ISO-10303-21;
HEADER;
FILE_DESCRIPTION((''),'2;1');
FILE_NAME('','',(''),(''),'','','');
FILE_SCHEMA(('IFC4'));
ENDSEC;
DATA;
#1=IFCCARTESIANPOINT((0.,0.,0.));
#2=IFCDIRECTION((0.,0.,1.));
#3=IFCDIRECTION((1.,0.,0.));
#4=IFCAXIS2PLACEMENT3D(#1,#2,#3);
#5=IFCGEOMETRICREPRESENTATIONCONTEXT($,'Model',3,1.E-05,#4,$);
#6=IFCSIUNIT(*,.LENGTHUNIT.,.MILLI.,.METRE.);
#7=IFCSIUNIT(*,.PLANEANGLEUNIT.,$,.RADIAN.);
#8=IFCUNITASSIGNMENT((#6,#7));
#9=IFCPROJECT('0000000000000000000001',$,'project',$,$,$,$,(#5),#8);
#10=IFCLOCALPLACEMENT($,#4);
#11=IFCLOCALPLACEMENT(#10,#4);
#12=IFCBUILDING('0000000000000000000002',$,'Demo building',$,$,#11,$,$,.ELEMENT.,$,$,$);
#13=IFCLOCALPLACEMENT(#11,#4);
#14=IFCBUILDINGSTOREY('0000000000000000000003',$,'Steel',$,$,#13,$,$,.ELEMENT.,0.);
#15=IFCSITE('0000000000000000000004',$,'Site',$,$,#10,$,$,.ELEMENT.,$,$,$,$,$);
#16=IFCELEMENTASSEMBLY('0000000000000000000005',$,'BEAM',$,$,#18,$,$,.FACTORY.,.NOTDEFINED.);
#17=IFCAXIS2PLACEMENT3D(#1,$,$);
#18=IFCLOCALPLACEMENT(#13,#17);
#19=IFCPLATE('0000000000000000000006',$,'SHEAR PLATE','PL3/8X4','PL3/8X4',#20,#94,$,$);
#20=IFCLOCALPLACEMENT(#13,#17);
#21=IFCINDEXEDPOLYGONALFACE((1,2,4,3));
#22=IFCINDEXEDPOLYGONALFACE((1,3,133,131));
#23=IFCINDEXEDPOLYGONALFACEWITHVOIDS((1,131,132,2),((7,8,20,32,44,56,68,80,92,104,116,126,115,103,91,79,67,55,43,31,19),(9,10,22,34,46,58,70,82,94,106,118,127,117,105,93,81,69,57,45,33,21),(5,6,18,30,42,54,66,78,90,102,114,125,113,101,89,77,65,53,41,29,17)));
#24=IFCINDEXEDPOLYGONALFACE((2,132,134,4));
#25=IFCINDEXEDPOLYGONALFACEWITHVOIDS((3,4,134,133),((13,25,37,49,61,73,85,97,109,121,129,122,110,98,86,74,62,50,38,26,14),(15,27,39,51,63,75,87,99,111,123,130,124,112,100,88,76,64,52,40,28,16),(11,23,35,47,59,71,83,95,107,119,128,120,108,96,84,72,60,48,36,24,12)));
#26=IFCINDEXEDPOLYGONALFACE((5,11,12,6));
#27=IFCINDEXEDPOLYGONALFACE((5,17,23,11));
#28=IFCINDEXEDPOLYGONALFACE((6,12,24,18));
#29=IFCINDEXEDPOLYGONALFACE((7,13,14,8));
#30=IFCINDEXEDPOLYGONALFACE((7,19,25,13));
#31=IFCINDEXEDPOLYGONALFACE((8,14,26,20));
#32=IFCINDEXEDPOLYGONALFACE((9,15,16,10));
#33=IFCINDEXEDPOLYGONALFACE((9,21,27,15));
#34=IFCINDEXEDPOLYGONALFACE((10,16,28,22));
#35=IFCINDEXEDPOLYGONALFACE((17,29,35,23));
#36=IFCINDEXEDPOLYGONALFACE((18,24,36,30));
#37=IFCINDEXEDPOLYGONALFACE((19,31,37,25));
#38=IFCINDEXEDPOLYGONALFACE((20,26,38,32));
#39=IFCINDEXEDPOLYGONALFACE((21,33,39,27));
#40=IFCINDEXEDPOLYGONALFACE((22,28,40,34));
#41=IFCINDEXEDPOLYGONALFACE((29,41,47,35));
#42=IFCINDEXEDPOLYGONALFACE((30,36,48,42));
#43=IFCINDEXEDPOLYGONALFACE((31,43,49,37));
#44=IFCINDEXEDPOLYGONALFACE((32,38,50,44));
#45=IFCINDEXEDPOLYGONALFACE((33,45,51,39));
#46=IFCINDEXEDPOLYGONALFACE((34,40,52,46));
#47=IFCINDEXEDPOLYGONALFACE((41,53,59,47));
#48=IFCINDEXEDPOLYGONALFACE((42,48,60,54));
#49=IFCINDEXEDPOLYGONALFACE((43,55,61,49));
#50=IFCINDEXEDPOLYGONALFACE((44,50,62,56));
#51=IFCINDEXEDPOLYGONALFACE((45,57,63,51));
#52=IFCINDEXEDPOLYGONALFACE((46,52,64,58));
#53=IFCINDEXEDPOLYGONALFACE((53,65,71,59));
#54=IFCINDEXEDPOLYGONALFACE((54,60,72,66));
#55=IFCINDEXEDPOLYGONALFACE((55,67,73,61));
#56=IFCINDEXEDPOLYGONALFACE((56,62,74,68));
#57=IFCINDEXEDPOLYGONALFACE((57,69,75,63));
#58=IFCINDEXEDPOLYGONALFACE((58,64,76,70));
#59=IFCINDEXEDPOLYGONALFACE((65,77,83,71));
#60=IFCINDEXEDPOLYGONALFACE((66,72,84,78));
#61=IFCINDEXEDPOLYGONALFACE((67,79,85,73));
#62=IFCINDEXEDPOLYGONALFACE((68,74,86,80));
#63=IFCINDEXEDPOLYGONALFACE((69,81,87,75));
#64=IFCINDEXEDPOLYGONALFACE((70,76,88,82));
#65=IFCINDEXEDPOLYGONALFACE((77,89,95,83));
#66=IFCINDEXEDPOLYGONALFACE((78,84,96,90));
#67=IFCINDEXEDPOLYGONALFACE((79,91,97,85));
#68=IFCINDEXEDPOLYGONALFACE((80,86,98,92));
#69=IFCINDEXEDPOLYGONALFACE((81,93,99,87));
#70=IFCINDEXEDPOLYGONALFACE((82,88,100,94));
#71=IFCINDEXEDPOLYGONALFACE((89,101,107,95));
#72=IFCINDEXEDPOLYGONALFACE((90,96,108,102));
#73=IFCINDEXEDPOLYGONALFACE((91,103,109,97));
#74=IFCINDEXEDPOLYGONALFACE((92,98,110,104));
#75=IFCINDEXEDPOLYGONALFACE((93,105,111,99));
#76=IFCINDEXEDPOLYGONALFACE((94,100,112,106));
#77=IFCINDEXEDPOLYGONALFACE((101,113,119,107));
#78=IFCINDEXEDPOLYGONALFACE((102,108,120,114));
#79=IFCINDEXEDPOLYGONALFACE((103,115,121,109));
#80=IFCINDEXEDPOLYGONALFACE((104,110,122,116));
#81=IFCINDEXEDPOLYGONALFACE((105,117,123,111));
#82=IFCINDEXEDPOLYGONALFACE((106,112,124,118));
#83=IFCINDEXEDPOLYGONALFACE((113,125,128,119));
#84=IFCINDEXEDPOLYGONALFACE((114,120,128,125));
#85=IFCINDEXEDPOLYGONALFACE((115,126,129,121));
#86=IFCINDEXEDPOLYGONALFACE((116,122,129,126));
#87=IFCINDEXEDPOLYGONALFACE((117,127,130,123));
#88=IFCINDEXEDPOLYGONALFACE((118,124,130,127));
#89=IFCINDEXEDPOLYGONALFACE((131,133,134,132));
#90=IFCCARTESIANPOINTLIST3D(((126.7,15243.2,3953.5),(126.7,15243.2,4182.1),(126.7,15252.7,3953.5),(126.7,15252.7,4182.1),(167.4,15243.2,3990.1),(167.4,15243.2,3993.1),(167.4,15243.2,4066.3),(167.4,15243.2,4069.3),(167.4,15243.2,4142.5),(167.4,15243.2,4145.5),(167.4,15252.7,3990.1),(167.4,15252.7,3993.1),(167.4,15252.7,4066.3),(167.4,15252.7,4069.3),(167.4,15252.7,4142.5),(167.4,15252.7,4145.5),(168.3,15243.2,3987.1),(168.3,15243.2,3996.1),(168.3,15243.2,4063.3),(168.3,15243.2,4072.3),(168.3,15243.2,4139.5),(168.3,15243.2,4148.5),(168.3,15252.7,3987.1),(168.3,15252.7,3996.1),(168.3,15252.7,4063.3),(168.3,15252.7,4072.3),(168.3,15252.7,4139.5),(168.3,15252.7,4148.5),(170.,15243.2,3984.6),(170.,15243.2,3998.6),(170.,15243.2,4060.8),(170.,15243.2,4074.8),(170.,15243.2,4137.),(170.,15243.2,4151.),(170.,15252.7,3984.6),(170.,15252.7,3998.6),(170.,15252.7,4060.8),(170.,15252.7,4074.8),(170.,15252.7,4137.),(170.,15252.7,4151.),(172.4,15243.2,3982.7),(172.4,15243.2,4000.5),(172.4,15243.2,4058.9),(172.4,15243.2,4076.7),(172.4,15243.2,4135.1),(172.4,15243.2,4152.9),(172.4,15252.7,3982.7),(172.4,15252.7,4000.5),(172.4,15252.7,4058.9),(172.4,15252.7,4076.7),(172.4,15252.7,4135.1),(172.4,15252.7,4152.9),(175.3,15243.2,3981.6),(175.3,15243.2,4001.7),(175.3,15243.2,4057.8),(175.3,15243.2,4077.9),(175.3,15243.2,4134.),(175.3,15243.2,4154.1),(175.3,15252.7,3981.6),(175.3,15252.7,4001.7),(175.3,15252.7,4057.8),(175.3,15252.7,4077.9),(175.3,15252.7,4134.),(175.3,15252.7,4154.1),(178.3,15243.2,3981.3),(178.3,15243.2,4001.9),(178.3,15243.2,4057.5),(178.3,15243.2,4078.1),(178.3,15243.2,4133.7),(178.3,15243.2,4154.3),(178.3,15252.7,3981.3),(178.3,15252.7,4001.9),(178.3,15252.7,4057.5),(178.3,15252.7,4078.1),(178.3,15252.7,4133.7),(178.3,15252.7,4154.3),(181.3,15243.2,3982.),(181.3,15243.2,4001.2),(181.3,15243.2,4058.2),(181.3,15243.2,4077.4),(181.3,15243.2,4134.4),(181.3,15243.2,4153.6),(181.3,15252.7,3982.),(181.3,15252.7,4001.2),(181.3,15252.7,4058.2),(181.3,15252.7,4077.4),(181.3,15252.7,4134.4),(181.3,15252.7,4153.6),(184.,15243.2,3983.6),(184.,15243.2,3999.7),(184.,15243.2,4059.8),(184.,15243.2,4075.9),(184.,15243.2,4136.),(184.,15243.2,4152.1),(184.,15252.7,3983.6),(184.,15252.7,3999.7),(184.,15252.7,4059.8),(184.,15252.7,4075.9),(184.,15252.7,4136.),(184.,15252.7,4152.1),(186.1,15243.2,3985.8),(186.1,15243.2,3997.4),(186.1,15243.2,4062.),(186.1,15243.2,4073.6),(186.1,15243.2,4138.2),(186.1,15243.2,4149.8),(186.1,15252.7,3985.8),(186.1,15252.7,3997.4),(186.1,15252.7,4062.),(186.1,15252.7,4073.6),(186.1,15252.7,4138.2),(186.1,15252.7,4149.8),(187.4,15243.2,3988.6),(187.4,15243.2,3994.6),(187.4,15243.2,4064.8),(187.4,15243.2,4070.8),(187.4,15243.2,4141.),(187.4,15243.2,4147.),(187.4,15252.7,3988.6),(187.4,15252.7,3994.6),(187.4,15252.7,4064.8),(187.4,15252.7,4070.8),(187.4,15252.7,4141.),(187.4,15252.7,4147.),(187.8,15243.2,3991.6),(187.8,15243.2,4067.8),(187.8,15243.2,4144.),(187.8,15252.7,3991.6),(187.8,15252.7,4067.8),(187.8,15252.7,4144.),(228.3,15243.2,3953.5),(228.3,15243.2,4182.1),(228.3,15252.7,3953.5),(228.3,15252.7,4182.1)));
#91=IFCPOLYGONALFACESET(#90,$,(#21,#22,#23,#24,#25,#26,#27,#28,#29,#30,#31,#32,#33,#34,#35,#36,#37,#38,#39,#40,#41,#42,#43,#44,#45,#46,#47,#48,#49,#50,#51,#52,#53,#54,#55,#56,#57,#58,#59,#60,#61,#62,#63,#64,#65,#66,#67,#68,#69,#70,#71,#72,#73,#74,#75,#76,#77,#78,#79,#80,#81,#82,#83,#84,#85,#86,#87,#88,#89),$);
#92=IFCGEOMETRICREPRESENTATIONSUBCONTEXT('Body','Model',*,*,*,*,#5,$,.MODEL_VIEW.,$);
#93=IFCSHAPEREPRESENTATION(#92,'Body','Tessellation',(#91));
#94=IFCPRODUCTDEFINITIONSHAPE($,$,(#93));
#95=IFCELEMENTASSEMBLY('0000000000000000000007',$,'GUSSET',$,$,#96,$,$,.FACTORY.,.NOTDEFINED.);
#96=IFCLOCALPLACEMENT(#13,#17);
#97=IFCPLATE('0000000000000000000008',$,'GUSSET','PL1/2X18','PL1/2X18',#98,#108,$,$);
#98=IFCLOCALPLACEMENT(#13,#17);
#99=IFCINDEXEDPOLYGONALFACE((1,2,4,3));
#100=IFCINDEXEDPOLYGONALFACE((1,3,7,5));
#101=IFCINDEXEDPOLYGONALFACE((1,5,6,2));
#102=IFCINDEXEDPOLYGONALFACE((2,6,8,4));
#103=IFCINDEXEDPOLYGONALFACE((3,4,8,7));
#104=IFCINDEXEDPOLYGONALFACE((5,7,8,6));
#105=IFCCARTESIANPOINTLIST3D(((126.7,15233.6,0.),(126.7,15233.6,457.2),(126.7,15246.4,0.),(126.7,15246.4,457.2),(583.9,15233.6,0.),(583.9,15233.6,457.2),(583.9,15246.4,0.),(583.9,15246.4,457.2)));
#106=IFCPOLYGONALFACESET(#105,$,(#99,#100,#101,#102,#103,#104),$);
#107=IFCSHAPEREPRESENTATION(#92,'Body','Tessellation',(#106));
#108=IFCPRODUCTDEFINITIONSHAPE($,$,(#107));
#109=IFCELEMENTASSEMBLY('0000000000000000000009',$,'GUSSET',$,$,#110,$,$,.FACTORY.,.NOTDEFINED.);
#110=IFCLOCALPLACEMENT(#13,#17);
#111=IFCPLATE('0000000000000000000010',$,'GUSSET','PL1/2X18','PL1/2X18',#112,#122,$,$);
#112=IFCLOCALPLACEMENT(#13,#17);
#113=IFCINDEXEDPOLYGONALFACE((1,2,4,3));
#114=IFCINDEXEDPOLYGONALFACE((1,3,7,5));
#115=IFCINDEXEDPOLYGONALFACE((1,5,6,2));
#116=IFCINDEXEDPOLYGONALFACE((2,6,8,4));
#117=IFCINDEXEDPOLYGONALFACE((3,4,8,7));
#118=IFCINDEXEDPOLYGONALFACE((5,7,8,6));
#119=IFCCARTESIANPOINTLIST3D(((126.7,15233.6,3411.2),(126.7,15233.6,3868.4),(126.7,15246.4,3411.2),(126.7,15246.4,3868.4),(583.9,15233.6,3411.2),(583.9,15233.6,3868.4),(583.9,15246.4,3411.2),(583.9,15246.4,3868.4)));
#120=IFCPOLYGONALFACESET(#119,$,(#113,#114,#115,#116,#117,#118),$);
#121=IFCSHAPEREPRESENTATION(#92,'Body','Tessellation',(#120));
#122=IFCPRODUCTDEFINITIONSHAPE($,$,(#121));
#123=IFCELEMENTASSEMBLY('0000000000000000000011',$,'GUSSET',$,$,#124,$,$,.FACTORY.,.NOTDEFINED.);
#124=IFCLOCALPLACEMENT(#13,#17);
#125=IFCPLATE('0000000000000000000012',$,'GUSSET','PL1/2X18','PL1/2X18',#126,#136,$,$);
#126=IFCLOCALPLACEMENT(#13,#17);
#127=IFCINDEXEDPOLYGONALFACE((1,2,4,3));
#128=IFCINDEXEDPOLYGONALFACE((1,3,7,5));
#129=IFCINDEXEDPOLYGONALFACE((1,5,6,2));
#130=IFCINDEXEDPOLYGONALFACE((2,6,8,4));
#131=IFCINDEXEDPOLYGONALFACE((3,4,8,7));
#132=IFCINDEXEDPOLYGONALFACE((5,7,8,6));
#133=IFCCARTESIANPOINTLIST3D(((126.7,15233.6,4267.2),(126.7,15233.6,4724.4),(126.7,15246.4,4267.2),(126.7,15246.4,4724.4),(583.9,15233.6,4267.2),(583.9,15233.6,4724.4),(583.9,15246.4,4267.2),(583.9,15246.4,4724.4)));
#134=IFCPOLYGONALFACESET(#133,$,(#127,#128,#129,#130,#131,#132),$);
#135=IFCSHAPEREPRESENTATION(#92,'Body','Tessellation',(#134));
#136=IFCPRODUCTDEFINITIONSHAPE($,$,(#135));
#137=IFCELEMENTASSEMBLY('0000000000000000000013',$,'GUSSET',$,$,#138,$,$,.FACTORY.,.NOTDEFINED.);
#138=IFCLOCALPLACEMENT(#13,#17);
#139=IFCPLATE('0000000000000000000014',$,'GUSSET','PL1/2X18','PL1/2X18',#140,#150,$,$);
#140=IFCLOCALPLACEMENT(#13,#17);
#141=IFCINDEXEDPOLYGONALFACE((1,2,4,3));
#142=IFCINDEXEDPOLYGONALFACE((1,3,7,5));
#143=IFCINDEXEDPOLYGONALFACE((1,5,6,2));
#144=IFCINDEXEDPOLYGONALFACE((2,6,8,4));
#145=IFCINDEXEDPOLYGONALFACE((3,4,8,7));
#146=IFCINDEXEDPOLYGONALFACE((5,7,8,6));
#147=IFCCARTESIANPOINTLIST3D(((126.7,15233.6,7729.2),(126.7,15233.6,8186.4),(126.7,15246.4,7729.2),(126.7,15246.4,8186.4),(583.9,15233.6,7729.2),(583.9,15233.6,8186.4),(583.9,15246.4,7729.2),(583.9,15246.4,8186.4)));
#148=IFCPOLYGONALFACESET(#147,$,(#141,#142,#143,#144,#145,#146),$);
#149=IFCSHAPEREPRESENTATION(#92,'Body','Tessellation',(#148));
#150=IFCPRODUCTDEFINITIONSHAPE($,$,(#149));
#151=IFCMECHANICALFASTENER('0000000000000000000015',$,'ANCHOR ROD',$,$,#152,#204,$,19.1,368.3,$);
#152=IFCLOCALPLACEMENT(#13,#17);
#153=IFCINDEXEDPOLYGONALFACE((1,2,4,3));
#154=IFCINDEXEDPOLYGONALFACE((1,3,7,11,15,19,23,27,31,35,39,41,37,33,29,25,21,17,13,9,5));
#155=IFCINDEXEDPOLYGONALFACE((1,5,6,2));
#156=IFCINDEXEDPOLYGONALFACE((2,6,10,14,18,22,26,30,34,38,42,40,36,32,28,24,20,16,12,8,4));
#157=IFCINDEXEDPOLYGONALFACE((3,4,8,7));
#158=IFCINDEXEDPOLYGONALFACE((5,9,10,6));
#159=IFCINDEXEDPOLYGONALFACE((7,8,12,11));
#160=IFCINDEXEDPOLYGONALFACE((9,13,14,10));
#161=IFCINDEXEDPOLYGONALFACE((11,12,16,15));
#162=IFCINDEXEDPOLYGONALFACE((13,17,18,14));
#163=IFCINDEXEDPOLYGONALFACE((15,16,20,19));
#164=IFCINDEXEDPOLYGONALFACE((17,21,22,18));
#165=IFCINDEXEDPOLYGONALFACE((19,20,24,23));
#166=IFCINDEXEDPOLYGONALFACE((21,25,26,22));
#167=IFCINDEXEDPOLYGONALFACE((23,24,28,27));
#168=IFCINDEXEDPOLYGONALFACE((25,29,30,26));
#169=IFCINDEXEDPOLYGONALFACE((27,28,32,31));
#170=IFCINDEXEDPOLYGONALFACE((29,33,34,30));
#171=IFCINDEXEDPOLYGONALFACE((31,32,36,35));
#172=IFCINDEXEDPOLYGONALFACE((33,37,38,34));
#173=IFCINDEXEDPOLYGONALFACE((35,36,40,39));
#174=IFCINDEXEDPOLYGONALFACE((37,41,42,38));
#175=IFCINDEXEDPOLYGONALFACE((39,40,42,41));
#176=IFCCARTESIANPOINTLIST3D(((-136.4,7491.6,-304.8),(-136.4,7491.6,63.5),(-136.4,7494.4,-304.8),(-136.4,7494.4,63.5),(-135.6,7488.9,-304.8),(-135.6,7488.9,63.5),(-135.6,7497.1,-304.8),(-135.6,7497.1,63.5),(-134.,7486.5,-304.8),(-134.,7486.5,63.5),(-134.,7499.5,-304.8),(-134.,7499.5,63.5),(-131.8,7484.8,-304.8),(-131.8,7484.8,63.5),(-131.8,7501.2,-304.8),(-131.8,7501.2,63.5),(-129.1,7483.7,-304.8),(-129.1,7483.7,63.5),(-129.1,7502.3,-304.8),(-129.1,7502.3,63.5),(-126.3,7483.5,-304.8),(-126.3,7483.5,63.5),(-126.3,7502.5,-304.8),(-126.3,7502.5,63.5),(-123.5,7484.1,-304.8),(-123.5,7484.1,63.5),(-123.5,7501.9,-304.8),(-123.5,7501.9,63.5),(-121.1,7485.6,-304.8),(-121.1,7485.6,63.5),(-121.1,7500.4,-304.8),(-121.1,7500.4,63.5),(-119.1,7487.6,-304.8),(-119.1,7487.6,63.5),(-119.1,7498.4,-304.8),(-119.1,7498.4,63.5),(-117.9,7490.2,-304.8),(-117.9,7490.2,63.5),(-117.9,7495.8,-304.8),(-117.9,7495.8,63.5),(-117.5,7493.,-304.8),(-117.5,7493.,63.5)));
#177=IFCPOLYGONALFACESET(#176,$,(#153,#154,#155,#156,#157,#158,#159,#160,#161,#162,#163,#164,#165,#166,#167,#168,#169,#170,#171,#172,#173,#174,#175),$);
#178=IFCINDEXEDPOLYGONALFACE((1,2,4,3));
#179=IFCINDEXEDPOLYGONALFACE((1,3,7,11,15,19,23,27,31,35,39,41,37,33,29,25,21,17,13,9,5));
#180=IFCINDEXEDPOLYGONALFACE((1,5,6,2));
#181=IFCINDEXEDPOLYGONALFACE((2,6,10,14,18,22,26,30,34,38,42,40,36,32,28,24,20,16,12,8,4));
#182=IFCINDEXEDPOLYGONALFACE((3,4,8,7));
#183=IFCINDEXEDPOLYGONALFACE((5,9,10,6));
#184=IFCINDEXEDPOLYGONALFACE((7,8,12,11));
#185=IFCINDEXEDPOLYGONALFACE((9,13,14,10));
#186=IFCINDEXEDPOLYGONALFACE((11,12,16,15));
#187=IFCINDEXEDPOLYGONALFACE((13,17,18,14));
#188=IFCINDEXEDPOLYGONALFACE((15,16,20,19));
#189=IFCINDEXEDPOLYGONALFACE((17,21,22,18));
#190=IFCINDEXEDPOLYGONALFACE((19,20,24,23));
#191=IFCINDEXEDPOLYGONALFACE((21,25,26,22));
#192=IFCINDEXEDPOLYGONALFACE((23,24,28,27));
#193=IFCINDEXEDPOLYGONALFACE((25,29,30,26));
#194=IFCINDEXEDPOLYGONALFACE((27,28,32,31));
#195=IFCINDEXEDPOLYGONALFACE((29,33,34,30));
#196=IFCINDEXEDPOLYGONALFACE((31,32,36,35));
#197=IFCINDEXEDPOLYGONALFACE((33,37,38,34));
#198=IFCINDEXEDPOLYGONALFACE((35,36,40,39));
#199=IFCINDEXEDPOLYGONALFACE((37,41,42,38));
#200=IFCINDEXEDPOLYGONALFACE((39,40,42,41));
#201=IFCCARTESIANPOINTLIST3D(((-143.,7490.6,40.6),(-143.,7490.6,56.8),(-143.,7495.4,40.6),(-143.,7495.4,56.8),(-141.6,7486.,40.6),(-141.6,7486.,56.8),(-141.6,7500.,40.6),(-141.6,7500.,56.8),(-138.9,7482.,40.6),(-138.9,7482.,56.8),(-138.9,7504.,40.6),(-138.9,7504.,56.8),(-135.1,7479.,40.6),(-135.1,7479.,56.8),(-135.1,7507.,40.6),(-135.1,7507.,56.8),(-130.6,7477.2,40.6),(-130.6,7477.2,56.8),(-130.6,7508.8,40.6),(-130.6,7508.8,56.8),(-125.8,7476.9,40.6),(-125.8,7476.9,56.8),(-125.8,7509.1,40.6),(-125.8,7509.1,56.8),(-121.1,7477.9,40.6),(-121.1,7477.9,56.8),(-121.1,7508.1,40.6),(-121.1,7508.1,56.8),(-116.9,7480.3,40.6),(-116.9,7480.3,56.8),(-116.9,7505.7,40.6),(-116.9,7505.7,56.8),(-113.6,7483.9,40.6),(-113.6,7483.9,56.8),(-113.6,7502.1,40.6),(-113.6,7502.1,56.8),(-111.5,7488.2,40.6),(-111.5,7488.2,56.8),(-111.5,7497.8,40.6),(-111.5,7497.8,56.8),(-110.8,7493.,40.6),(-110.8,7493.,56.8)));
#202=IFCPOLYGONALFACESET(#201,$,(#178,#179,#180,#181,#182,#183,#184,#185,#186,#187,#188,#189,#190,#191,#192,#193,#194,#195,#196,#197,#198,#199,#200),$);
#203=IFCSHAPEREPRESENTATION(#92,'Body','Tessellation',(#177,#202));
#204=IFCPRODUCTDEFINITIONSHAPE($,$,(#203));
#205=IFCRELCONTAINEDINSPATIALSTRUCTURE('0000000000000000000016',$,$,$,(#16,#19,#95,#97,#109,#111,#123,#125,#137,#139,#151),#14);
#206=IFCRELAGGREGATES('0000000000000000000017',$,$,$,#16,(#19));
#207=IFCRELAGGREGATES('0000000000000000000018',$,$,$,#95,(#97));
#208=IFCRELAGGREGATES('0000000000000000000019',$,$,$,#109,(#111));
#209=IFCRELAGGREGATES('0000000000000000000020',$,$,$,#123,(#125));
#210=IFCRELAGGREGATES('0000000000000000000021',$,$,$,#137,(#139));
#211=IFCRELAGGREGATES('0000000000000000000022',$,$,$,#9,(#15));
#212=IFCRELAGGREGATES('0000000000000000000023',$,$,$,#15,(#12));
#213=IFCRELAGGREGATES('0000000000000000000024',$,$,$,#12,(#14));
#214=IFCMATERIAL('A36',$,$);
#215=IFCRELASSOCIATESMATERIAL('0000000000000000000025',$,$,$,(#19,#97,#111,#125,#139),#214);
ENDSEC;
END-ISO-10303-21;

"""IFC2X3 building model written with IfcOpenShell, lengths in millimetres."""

from ifc_helpers import new_model, si_unit, frame, frame_2d, origin, origin_with_axes, origin_2d, place, context, subcontext, project, spatial, rectangle, circle, extrude, boolean, material, element, aggregate, save


model = new_model("IFC2X3")

# Units and contexts
model_context = context("Model", 3, precision=1e-05, world=origin_with_axes())
body_context = subcontext(model_context, "Body", "Model", "MODEL_VIEW")
ifc_project = project(units=[si_unit("LENGTHUNIT", "METRE", prefix="MILLI"), si_unit("PLANEANGLEUNIT", "RADIAN")], contexts=[model_context])

# Site, building, storey
site_placement = place(None, origin_with_axes())
site = spatial("IfcSite", under=ifc_project, at=site_placement, Name="Site", CompositionType="ELEMENT")
building_placement = place(site_placement, origin_with_axes())
building = spatial("IfcBuilding", under=site, at=building_placement, Name="Demo building", CompositionType="ELEMENT")
placement = place(building_placement, origin_with_axes())
storey = spatial("IfcBuildingStorey", under=building, at=placement, Name="Steel", CompositionType="ELEMENT", Elevation=0.0)

# Element assembly
assembly_1 = element("IfcElementAssembly", 1, at=placement, inside=storey, Name="BEAM", AssemblyPlace="FACTORY", PredefinedType="NOTDEFINED")

# Plate
ifc_material_1 = material(Name="A36")
plate_1_placement = place(placement, frame((126.7, 15252.7, 3953.5), z_axis=(0.0, -1.0, 0.0), x_axis=(1.0, 0.0, 0.0)))
plate_1 = element("IfcPlate", 2, at=plate_1_placement, inside=storey, material=ifc_material_1, Name="SHEAR PLATE", Description="PL3/8X4", ObjectType="PL3/8X4", context=body_context, shape_type="CSG", body=[
    boolean("DIFFERENCE", boolean("DIFFERENCE", boolean("DIFFERENCE", extrude(rectangle(XDim=101.6, YDim=228.6, at=frame_2d((50.8, 114.3))), origin(), (0.0, 0.0, 1.0), 9.5), extrude(circle(Radius=10.3, at=frame_2d((50.8, 38.1))), frame((0.0, 0.0, -5.0)), (0.0, 0.0, 1.0), 19.5)), extrude(circle(Radius=10.3, at=frame_2d((50.8, 114.3))), frame((0.0, 0.0, -5.0)), (0.0, 0.0, 1.0), 19.5)), extrude(circle(Radius=10.3, at=frame_2d((50.8, 190.5))), frame((0.0, 0.0, -5.0)), (0.0, 0.0, 1.0), 19.5)),
])
aggregate(assembly_1, [plate_1])

# Element assemblies, plates
assembly_2 = element("IfcElementAssembly", 3, at=placement, inside=storey, Name="GUSSET", AssemblyPlace="FACTORY", PredefinedType="NOTDEFINED")
plate_2_placement = place(placement, frame((126.7, 15246.4, 0.0), z_axis=(0.0, -1.0, 0.0), x_axis=(1.0, 0.0, 0.0)))
plate_2 = element("IfcPlate", 4, at=plate_2_placement, inside=storey, material=ifc_material_1, Name="GUSSET", Description="PL1/2X18", ObjectType="PL1/2X18", context=body_context, shape_type="SweptSolid", body=[
    extrude(rectangle(XDim=457.2, YDim=457.2, at=frame_2d((228.6, 228.6))), origin(), (0.0, 0.0, 1.0), 12.7),
])
aggregate(assembly_2, [plate_2])
assembly_3 = element("IfcElementAssembly", 5, at=placement, inside=storey, Name="GUSSET", AssemblyPlace="FACTORY", PredefinedType="NOTDEFINED")
plate_3_placement = place(placement, frame((126.7, 15246.4, 3411.2), z_axis=(0.0, -1.0, 0.0), x_axis=(1.0, 0.0, 0.0)))
plate_3 = element("IfcPlate", 6, at=plate_3_placement, inside=storey, material=ifc_material_1, Name="GUSSET", Description="PL1/2X18", ObjectType="PL1/2X18", context=body_context, shape_type="SweptSolid", body=[
    extrude(rectangle(XDim=457.2, YDim=457.2, at=frame_2d((228.6, 228.6))), origin(), (0.0, 0.0, 1.0), 12.7),
])
aggregate(assembly_3, [plate_3])
assembly_4 = element("IfcElementAssembly", 7, at=placement, inside=storey, Name="GUSSET", AssemblyPlace="FACTORY", PredefinedType="NOTDEFINED")
plate_4_placement = place(placement, frame((126.7, 15246.4, 4267.2), z_axis=(0.0, -1.0, 0.0), x_axis=(1.0, 0.0, 0.0)))
plate_4 = element("IfcPlate", 8, at=plate_4_placement, inside=storey, material=ifc_material_1, Name="GUSSET", Description="PL1/2X18", ObjectType="PL1/2X18", context=body_context, shape_type="SweptSolid", body=[
    extrude(rectangle(XDim=457.2, YDim=457.2, at=frame_2d((228.6, 228.6))), origin(), (0.0, 0.0, 1.0), 12.7),
])
aggregate(assembly_4, [plate_4])
assembly_5 = element("IfcElementAssembly", 9, at=placement, inside=storey, Name="GUSSET", AssemblyPlace="FACTORY", PredefinedType="NOTDEFINED")
plate_5_placement = place(placement, frame((126.7, 15246.4, 7729.2), z_axis=(0.0, -1.0, 0.0), x_axis=(1.0, 0.0, 0.0)))
plate_5 = element("IfcPlate", 10, at=plate_5_placement, inside=storey, material=ifc_material_1, Name="GUSSET", Description="PL1/2X18", ObjectType="PL1/2X18", context=body_context, shape_type="SweptSolid", body=[
    extrude(rectangle(XDim=457.2, YDim=457.2, at=frame_2d((228.6, 228.6))), origin(), (0.0, 0.0, 1.0), 12.7),
])
aggregate(assembly_5, [plate_5])

# Mechanical fastener
for number, where, z_axis, x_axis, name in (
    (11, (-127.0, 7493.0, -304.8), (0.0, 0.0, 1.0), (1.0, 0.0, 0.0), "ANCHOR ROD"),
):
    element("IfcMechanicalFastener", number, at=place(placement, frame(where, z_axis=z_axis, x_axis=x_axis)), inside=storey, Name=name, NominalDiameter=19.1, NominalLength=368.3, context=body_context, shape_type="SweptSolid", body=[
        extrude(circle(Radius=9.5, at=origin_2d()), origin(), (0.0, 0.0, 1.0), 368.3),
        extrude(circle(Radius=16.2, at=origin_2d()), frame((0.0, 0.0, 345.4)), (0.0, 0.0, 1.0), 16.2),
    ])

save(model, "model.ifc")
